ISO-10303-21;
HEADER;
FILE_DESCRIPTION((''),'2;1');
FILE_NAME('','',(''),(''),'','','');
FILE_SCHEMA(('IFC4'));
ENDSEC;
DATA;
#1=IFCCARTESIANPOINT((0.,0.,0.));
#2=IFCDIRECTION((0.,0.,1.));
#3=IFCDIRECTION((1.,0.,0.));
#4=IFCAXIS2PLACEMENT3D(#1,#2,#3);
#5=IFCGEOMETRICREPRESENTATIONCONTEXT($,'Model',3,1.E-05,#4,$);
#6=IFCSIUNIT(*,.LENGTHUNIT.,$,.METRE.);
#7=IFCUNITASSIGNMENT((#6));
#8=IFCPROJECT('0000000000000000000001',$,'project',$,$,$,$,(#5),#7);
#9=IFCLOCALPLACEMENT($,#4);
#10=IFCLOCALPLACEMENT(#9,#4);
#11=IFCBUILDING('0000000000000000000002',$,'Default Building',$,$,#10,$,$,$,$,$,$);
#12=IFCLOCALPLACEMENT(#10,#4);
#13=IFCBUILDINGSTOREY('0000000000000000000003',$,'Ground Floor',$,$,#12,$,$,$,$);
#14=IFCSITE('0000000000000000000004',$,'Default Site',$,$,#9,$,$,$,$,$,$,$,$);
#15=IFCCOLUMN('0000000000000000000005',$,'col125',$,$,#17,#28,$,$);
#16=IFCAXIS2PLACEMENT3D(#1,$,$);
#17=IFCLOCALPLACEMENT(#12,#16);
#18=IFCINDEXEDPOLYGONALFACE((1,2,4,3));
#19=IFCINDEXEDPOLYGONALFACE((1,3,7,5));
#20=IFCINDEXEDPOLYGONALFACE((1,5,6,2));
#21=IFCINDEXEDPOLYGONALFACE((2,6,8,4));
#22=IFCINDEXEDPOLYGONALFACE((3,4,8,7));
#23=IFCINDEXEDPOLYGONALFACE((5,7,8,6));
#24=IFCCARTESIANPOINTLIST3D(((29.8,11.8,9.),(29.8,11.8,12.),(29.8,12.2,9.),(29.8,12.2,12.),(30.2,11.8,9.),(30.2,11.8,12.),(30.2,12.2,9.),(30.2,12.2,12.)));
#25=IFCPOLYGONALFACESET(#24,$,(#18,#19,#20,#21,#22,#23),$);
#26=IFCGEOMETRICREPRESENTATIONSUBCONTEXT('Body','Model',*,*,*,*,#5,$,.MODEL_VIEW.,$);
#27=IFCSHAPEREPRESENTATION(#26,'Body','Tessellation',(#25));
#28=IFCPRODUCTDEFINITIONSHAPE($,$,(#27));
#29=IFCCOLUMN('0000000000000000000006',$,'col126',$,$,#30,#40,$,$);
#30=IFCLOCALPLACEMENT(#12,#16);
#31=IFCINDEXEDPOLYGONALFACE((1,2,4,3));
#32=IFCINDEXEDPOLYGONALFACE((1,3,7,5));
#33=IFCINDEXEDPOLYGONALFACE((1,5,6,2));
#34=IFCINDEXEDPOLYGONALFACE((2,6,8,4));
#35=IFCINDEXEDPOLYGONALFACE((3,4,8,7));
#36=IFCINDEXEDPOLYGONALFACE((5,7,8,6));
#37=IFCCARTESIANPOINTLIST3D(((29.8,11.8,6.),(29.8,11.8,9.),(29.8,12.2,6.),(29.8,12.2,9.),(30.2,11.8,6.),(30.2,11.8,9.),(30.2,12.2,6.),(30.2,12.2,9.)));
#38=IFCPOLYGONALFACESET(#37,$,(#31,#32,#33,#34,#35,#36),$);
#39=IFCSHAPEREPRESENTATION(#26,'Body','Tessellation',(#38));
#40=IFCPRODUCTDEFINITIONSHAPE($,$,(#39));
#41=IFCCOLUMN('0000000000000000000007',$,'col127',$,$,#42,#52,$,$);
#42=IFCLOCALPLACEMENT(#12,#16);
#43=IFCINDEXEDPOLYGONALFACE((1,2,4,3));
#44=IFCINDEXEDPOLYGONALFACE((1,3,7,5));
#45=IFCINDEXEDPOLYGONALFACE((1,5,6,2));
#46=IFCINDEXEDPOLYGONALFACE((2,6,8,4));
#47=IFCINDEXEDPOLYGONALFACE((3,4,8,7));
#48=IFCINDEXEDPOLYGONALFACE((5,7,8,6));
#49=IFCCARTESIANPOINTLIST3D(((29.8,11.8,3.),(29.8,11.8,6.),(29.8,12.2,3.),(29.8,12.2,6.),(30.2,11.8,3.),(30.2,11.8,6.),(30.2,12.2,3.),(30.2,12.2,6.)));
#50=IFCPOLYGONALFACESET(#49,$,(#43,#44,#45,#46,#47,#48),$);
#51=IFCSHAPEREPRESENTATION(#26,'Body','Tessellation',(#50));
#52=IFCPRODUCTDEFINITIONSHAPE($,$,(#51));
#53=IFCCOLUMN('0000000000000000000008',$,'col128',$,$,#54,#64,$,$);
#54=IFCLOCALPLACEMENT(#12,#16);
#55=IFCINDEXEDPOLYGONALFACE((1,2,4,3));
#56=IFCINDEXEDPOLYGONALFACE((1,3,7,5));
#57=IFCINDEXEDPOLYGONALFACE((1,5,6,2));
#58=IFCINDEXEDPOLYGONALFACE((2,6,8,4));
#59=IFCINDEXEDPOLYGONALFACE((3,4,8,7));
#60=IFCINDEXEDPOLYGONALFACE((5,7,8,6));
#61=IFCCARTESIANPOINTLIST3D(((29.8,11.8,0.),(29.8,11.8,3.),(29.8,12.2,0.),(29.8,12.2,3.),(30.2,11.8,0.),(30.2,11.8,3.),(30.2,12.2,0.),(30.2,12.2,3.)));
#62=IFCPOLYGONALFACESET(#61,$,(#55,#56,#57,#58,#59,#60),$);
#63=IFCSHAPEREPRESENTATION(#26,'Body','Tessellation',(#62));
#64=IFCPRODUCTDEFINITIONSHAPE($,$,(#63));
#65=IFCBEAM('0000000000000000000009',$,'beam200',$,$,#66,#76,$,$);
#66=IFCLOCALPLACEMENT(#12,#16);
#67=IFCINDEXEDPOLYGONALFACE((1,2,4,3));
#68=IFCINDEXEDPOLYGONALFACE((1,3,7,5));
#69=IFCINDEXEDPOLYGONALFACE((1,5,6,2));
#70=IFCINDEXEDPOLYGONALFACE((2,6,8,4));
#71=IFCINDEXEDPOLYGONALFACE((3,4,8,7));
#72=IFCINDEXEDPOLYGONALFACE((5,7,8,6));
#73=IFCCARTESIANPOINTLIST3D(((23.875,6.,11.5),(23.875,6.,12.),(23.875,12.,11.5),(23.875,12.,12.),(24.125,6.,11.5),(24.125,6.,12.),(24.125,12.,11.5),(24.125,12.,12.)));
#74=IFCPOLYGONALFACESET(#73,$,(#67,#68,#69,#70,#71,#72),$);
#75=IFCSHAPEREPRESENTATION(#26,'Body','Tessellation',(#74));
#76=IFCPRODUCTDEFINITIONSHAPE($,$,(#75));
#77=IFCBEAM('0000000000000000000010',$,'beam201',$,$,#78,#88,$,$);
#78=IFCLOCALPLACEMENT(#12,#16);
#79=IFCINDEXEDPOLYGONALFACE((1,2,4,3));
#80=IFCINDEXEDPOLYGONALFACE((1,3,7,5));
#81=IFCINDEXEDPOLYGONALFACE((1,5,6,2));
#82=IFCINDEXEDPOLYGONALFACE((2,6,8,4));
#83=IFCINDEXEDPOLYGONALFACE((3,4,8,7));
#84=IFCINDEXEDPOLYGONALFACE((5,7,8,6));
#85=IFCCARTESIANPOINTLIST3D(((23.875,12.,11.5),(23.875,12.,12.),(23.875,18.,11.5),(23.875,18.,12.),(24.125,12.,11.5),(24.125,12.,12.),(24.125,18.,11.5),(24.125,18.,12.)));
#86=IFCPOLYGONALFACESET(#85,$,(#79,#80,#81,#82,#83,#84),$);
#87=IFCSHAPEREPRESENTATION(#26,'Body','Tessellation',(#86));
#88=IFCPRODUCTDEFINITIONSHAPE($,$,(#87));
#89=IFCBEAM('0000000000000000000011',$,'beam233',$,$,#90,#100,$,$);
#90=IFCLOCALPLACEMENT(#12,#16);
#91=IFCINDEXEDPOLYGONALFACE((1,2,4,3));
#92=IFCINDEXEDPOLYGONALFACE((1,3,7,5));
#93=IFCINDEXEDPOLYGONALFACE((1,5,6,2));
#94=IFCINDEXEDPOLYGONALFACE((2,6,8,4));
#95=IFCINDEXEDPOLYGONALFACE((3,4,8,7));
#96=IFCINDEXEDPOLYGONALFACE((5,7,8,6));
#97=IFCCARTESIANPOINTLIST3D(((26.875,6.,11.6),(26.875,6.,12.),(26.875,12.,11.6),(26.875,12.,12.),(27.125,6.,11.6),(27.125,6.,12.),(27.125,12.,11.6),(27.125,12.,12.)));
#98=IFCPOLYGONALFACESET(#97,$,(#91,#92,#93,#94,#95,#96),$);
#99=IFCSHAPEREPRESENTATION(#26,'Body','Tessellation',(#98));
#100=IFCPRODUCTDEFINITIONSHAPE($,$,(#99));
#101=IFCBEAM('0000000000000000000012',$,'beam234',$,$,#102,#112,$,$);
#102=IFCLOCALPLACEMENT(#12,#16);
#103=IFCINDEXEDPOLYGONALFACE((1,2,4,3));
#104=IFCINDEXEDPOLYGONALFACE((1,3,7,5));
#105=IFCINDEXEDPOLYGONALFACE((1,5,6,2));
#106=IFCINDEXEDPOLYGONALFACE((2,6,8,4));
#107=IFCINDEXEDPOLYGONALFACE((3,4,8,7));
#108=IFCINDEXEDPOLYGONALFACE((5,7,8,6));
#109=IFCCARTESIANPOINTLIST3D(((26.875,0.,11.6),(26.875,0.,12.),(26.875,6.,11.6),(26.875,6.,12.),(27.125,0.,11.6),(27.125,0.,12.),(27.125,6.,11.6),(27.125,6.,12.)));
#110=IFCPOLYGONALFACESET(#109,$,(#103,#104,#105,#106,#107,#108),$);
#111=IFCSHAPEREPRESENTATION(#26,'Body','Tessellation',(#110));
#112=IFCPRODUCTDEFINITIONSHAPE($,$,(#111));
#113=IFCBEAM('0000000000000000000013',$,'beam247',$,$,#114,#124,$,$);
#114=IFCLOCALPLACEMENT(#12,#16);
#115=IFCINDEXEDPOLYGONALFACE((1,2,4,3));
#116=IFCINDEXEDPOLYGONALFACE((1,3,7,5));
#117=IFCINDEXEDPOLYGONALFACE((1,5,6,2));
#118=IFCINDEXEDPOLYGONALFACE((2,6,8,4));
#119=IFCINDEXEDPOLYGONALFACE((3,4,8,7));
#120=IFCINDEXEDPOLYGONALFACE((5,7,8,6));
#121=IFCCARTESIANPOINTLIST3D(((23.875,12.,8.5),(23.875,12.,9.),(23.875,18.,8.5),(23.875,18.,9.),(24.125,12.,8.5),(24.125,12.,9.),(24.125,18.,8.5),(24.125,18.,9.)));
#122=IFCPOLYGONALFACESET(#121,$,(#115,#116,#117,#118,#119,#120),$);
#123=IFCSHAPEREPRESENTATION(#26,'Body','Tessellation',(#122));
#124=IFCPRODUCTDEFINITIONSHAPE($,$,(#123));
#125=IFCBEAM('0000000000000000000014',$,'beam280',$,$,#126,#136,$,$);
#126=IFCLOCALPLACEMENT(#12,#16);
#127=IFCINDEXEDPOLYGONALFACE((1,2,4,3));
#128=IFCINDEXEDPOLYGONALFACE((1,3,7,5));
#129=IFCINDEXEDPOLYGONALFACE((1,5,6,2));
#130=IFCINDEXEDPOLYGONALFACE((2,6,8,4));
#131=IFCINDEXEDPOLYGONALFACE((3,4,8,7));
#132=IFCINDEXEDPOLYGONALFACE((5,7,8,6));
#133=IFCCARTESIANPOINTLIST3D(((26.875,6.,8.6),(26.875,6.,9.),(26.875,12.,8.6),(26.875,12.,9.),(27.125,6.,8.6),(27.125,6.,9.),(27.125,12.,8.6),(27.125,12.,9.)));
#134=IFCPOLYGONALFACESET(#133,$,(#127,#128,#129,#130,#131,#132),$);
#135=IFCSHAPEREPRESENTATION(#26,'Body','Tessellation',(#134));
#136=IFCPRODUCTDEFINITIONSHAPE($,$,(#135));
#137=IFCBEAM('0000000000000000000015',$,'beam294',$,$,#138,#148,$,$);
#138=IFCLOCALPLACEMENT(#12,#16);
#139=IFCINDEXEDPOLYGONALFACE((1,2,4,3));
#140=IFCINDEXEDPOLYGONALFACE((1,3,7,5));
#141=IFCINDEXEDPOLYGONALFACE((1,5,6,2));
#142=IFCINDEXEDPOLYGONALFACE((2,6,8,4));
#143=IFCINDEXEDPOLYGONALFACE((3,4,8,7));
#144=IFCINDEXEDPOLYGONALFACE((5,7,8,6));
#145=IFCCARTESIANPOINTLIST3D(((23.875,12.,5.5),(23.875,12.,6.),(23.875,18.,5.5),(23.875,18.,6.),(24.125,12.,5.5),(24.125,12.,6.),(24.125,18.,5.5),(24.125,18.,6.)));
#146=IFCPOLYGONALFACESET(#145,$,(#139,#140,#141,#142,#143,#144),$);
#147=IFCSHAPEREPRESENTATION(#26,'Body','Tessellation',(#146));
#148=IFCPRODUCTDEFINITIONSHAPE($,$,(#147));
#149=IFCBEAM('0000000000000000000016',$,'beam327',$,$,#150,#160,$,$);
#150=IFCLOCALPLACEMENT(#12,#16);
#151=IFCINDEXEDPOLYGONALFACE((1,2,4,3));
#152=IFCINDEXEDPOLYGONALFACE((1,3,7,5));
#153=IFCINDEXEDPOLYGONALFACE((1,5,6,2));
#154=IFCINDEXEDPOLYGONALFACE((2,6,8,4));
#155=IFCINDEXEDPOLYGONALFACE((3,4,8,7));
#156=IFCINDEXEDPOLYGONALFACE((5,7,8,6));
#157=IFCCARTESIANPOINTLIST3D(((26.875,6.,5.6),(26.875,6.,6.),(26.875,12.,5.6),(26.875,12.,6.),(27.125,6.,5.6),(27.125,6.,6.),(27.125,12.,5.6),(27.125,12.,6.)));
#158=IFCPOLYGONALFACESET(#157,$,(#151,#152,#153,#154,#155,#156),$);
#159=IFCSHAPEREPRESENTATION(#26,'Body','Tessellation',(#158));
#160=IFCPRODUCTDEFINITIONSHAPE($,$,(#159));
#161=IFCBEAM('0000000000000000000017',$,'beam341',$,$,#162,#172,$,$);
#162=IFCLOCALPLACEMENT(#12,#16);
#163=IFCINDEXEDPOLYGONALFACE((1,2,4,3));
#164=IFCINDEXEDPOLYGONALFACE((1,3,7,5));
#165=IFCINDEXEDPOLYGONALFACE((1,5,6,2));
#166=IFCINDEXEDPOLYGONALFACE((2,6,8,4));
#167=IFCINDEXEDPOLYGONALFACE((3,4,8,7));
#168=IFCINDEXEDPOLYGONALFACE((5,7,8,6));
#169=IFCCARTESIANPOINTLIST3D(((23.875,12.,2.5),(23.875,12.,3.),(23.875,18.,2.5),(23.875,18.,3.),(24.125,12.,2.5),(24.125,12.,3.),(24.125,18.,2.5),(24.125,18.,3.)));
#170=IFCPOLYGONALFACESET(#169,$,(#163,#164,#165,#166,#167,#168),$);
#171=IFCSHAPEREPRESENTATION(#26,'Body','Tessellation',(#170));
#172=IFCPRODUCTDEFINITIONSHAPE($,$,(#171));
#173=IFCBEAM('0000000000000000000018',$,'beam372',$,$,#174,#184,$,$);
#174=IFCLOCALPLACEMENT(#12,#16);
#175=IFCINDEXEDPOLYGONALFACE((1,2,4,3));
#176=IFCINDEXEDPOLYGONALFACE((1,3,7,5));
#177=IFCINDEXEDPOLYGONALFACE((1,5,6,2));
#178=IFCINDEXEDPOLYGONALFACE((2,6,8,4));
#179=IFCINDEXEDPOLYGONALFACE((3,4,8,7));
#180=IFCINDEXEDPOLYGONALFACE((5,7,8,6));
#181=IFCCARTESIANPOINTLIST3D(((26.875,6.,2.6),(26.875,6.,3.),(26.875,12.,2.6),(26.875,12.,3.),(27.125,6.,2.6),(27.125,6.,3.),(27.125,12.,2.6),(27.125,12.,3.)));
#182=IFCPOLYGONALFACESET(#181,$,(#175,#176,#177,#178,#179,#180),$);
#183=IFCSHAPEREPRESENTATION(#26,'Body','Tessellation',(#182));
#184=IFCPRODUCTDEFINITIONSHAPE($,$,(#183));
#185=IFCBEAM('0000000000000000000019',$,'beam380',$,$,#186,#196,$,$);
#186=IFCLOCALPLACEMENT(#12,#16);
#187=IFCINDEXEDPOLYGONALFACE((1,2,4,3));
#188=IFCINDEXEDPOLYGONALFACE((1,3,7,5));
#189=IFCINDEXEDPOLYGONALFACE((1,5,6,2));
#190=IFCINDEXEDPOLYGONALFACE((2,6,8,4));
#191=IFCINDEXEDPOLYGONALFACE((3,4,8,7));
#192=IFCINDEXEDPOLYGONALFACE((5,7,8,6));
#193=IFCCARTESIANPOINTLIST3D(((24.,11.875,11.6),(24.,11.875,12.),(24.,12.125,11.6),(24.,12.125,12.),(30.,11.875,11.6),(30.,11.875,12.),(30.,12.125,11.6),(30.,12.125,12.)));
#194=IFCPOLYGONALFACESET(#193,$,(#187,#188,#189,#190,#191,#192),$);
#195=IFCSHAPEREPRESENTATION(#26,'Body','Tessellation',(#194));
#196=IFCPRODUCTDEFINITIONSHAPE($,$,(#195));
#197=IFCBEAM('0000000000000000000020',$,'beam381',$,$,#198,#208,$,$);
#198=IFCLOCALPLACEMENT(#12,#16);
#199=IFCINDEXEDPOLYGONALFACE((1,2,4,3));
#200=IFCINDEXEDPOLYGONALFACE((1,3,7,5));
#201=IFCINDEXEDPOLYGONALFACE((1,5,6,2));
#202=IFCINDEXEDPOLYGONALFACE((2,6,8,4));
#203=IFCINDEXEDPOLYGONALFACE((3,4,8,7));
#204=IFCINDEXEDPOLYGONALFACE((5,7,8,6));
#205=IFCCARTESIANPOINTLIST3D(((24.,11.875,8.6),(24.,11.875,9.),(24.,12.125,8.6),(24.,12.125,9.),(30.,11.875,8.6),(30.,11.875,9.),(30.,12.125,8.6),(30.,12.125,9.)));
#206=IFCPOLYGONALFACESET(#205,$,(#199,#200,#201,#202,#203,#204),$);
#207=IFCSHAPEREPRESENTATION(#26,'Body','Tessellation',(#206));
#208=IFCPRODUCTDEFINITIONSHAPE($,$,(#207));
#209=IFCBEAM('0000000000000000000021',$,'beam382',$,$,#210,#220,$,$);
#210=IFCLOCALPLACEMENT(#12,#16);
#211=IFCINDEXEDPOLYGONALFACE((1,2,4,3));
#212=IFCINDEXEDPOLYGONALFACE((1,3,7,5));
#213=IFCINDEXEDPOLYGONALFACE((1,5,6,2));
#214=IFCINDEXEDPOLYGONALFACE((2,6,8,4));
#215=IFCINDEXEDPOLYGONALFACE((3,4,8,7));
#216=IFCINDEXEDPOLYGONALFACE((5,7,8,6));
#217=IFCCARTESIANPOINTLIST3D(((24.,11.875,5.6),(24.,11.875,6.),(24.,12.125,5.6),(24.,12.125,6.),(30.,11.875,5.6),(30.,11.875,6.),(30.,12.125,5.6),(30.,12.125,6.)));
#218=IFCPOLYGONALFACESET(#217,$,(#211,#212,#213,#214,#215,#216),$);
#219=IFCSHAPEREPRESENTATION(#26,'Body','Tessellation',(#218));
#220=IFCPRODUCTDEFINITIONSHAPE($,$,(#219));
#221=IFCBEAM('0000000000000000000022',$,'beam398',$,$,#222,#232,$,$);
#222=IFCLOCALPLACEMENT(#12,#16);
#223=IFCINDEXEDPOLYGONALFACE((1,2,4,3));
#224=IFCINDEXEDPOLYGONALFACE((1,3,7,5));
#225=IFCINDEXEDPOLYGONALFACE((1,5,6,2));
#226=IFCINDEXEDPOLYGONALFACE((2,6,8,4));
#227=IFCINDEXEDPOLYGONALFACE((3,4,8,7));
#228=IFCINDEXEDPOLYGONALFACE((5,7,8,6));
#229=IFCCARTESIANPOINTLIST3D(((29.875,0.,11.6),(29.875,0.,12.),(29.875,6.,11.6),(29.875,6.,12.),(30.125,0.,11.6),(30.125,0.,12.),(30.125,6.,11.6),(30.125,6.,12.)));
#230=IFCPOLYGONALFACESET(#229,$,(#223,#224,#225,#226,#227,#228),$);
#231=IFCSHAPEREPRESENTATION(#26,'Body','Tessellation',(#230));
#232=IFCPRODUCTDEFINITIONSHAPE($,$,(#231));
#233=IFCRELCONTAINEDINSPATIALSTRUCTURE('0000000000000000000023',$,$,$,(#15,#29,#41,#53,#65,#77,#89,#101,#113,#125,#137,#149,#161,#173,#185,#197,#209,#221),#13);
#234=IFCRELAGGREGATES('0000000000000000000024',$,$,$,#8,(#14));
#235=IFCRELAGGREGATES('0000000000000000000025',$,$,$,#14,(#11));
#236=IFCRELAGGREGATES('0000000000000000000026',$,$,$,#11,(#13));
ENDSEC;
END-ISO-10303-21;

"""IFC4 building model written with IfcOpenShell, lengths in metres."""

from ifc_helpers import new_model, si_unit, frame, origin_with_axes, place, context, subcontext, project, spatial, indexed_curve, outline, extrude, element, save


model = new_model("IFC4")

# Units and contexts
model_context = context("Model", 3, precision=1e-05, world=origin_with_axes())
body_context = subcontext(model_context, "Body", "Model", "MODEL_VIEW")
ifc_project = project(units=[si_unit("LENGTHUNIT", "METRE")], contexts=[model_context])

# Site, building, storey
site_placement = place(None, origin_with_axes())
site = spatial("IfcSite", under=ifc_project, at=site_placement, Name="Default Site")
building_placement = place(site_placement, origin_with_axes())
building = spatial("IfcBuilding", under=site, at=building_placement, Name="Default Building")
storey_placement = place(building_placement, origin_with_axes())
storey = spatial("IfcBuildingStorey", under=building, at=storey_placement, Name="Ground Floor")

# Columns
for number, where, z_axis, x_axis, name in (
    (1, (29.8, 11.8, 9.0), (0.0, 0.0, 1.0), (1.0, 0.0, 0.0), "col125"),
    (2, (29.8, 11.8, 6.0), (0.0, 0.0, 1.0), (1.0, 0.0, 0.0), "col126"),
    (3, (29.8, 11.8, 3.0), (0.0, 0.0, 1.0), (1.0, 0.0, 0.0), "col127"),
    (4, (29.8, 11.8, 0.0), (0.0, 0.0, 1.0), (1.0, 0.0, 0.0), "col128"),
):
    element("IfcColumn", number, at=place(storey_placement, frame(where, z_axis=z_axis, x_axis=x_axis)), inside=storey, Name=name, context=body_context, shape_type="SweptSolid", body=[
        extrude(outline(indexed_curve([(0.0, 0.0), (0.0, 0.4), (0.4, 0.4), (0.4, 0.0), (0.0, 0.0)], self_intersect=False)), origin_with_axes(), (0.0, 0.0, 1.0), 3.0),
    ])

# Beams
for number, where, z_axis, x_axis, name in (
    (5, (24.125, 6.0, 11.5), (0.0, 0.0, 1.0), (0.0, 1.0, 0.0), "beam200"),
    (6, (24.125, 12.0, 11.5), (0.0, 0.0, 1.0), (0.0, 1.0, 0.0), "beam201"),
):
    element("IfcBeam", number, at=place(storey_placement, frame(where, z_axis=z_axis, x_axis=x_axis)), inside=storey, Name=name, context=body_context, shape_type="SweptSolid", body=[
        extrude(outline(indexed_curve([(0.0, 0.0), (0.0, 0.25), (6.0, 0.25), (6.0, 0.0), (0.0, 0.0)], self_intersect=False)), origin_with_axes(), (0.0, 0.0, 1.0), 0.5),
    ])
for number, where, z_axis, x_axis, name in (
    (7, (26.875, 12.0, 11.6), (0.0, 0.0, 1.0), (0.0, -1.0, 0.0), "beam233"),
    (8, (26.875, 6.0, 11.6), (0.0, 0.0, 1.0), (0.0, -1.0, 0.0), "beam234"),
):
    element("IfcBeam", number, at=place(storey_placement, frame(where, z_axis=z_axis, x_axis=x_axis)), inside=storey, Name=name, context=body_context, shape_type="SweptSolid", body=[
        extrude(outline(indexed_curve([(0.0, 0.0), (0.0, 0.25), (6.0, 0.25), (6.0, 0.0), (0.0, 0.0)], self_intersect=False)), origin_with_axes(), (0.0, 0.0, 1.0), 0.4),
    ])
beam_1_placement = place(storey_placement, frame((24.125, 12.0, 8.5), z_axis=(0.0, 0.0, 1.0), x_axis=(0.0, 1.0, 0.0)))
element("IfcBeam", 9, at=beam_1_placement, inside=storey, Name="beam247", context=body_context, shape_type="SweptSolid", body=[
    extrude(outline(indexed_curve([(0.0, 0.0), (0.0, 0.25), (6.0, 0.25), (6.0, 0.0), (0.0, 0.0)], self_intersect=False)), origin_with_axes(), (0.0, 0.0, 1.0), 0.5),
])
beam_2_placement = place(storey_placement, frame((26.875, 12.0, 8.6), z_axis=(0.0, 0.0, 1.0), x_axis=(0.0, -1.0, 0.0)))
element("IfcBeam", 10, at=beam_2_placement, inside=storey, Name="beam280", context=body_context, shape_type="SweptSolid", body=[
    extrude(outline(indexed_curve([(0.0, 0.0), (0.0, 0.25), (6.0, 0.25), (6.0, 0.0), (0.0, 0.0)], self_intersect=False)), origin_with_axes(), (0.0, 0.0, 1.0), 0.4),
])
beam_3_placement = place(storey_placement, frame((24.125, 12.0, 5.5), z_axis=(0.0, 0.0, 1.0), x_axis=(0.0, 1.0, 0.0)))
element("IfcBeam", 11, at=beam_3_placement, inside=storey, Name="beam294", context=body_context, shape_type="SweptSolid", body=[
    extrude(outline(indexed_curve([(0.0, 0.0), (0.0, 0.25), (6.0, 0.25), (6.0, 0.0), (0.0, 0.0)], self_intersect=False)), origin_with_axes(), (0.0, 0.0, 1.0), 0.5),
])
beam_4_placement = place(storey_placement, frame((26.875, 12.0, 5.6), z_axis=(0.0, 0.0, 1.0), x_axis=(0.0, -1.0, 0.0)))
element("IfcBeam", 12, at=beam_4_placement, inside=storey, Name="beam327", context=body_context, shape_type="SweptSolid", body=[
    extrude(outline(indexed_curve([(0.0, 0.0), (0.0, 0.25), (6.0, 0.25), (6.0, 0.0), (0.0, 0.0)], self_intersect=False)), origin_with_axes(), (0.0, 0.0, 1.0), 0.4),
])
beam_5_placement = place(storey_placement, frame((24.125, 12.0, 2.5), z_axis=(0.0, 0.0, 1.0), x_axis=(0.0, 1.0, 0.0)))
element("IfcBeam", 13, at=beam_5_placement, inside=storey, Name="beam341", context=body_context, shape_type="SweptSolid", body=[
    extrude(outline(indexed_curve([(0.0, 0.0), (0.0, 0.25), (6.0, 0.25), (6.0, 0.0), (0.0, 0.0)], self_intersect=False)), origin_with_axes(), (0.0, 0.0, 1.0), 0.5),
])
for number, where, z_axis, x_axis, name in (
    (14, (26.875, 12.0, 2.6), (0.0, 0.0, 1.0), (0.0, -1.0, 0.0), "beam372"),
    (15, (24.0, 11.875, 11.6), (0.0, 0.0, 1.0), (1.0, 0.0, 0.0), "beam380"),
    (16, (24.0, 11.875, 8.6), (0.0, 0.0, 1.0), (1.0, 0.0, 0.0), "beam381"),
    (17, (24.0, 11.875, 5.6), (0.0, 0.0, 1.0), (1.0, 0.0, 0.0), "beam382"),
    (18, (29.875, 6.0, 11.6), (0.0, 0.0, 1.0), (0.0, -1.0, 0.0), "beam398"),
):
    element("IfcBeam", number, at=place(storey_placement, frame(where, z_axis=z_axis, x_axis=x_axis)), inside=storey, Name=name, context=body_context, shape_type="SweptSolid", body=[
        extrude(outline(indexed_curve([(0.0, 0.0), (0.0, 0.25), (6.0, 0.25), (6.0, 0.0), (0.0, 0.0)], self_intersect=False)), origin_with_axes(), (0.0, 0.0, 1.0), 0.4),
    ])

save(model, "model.ifc")
